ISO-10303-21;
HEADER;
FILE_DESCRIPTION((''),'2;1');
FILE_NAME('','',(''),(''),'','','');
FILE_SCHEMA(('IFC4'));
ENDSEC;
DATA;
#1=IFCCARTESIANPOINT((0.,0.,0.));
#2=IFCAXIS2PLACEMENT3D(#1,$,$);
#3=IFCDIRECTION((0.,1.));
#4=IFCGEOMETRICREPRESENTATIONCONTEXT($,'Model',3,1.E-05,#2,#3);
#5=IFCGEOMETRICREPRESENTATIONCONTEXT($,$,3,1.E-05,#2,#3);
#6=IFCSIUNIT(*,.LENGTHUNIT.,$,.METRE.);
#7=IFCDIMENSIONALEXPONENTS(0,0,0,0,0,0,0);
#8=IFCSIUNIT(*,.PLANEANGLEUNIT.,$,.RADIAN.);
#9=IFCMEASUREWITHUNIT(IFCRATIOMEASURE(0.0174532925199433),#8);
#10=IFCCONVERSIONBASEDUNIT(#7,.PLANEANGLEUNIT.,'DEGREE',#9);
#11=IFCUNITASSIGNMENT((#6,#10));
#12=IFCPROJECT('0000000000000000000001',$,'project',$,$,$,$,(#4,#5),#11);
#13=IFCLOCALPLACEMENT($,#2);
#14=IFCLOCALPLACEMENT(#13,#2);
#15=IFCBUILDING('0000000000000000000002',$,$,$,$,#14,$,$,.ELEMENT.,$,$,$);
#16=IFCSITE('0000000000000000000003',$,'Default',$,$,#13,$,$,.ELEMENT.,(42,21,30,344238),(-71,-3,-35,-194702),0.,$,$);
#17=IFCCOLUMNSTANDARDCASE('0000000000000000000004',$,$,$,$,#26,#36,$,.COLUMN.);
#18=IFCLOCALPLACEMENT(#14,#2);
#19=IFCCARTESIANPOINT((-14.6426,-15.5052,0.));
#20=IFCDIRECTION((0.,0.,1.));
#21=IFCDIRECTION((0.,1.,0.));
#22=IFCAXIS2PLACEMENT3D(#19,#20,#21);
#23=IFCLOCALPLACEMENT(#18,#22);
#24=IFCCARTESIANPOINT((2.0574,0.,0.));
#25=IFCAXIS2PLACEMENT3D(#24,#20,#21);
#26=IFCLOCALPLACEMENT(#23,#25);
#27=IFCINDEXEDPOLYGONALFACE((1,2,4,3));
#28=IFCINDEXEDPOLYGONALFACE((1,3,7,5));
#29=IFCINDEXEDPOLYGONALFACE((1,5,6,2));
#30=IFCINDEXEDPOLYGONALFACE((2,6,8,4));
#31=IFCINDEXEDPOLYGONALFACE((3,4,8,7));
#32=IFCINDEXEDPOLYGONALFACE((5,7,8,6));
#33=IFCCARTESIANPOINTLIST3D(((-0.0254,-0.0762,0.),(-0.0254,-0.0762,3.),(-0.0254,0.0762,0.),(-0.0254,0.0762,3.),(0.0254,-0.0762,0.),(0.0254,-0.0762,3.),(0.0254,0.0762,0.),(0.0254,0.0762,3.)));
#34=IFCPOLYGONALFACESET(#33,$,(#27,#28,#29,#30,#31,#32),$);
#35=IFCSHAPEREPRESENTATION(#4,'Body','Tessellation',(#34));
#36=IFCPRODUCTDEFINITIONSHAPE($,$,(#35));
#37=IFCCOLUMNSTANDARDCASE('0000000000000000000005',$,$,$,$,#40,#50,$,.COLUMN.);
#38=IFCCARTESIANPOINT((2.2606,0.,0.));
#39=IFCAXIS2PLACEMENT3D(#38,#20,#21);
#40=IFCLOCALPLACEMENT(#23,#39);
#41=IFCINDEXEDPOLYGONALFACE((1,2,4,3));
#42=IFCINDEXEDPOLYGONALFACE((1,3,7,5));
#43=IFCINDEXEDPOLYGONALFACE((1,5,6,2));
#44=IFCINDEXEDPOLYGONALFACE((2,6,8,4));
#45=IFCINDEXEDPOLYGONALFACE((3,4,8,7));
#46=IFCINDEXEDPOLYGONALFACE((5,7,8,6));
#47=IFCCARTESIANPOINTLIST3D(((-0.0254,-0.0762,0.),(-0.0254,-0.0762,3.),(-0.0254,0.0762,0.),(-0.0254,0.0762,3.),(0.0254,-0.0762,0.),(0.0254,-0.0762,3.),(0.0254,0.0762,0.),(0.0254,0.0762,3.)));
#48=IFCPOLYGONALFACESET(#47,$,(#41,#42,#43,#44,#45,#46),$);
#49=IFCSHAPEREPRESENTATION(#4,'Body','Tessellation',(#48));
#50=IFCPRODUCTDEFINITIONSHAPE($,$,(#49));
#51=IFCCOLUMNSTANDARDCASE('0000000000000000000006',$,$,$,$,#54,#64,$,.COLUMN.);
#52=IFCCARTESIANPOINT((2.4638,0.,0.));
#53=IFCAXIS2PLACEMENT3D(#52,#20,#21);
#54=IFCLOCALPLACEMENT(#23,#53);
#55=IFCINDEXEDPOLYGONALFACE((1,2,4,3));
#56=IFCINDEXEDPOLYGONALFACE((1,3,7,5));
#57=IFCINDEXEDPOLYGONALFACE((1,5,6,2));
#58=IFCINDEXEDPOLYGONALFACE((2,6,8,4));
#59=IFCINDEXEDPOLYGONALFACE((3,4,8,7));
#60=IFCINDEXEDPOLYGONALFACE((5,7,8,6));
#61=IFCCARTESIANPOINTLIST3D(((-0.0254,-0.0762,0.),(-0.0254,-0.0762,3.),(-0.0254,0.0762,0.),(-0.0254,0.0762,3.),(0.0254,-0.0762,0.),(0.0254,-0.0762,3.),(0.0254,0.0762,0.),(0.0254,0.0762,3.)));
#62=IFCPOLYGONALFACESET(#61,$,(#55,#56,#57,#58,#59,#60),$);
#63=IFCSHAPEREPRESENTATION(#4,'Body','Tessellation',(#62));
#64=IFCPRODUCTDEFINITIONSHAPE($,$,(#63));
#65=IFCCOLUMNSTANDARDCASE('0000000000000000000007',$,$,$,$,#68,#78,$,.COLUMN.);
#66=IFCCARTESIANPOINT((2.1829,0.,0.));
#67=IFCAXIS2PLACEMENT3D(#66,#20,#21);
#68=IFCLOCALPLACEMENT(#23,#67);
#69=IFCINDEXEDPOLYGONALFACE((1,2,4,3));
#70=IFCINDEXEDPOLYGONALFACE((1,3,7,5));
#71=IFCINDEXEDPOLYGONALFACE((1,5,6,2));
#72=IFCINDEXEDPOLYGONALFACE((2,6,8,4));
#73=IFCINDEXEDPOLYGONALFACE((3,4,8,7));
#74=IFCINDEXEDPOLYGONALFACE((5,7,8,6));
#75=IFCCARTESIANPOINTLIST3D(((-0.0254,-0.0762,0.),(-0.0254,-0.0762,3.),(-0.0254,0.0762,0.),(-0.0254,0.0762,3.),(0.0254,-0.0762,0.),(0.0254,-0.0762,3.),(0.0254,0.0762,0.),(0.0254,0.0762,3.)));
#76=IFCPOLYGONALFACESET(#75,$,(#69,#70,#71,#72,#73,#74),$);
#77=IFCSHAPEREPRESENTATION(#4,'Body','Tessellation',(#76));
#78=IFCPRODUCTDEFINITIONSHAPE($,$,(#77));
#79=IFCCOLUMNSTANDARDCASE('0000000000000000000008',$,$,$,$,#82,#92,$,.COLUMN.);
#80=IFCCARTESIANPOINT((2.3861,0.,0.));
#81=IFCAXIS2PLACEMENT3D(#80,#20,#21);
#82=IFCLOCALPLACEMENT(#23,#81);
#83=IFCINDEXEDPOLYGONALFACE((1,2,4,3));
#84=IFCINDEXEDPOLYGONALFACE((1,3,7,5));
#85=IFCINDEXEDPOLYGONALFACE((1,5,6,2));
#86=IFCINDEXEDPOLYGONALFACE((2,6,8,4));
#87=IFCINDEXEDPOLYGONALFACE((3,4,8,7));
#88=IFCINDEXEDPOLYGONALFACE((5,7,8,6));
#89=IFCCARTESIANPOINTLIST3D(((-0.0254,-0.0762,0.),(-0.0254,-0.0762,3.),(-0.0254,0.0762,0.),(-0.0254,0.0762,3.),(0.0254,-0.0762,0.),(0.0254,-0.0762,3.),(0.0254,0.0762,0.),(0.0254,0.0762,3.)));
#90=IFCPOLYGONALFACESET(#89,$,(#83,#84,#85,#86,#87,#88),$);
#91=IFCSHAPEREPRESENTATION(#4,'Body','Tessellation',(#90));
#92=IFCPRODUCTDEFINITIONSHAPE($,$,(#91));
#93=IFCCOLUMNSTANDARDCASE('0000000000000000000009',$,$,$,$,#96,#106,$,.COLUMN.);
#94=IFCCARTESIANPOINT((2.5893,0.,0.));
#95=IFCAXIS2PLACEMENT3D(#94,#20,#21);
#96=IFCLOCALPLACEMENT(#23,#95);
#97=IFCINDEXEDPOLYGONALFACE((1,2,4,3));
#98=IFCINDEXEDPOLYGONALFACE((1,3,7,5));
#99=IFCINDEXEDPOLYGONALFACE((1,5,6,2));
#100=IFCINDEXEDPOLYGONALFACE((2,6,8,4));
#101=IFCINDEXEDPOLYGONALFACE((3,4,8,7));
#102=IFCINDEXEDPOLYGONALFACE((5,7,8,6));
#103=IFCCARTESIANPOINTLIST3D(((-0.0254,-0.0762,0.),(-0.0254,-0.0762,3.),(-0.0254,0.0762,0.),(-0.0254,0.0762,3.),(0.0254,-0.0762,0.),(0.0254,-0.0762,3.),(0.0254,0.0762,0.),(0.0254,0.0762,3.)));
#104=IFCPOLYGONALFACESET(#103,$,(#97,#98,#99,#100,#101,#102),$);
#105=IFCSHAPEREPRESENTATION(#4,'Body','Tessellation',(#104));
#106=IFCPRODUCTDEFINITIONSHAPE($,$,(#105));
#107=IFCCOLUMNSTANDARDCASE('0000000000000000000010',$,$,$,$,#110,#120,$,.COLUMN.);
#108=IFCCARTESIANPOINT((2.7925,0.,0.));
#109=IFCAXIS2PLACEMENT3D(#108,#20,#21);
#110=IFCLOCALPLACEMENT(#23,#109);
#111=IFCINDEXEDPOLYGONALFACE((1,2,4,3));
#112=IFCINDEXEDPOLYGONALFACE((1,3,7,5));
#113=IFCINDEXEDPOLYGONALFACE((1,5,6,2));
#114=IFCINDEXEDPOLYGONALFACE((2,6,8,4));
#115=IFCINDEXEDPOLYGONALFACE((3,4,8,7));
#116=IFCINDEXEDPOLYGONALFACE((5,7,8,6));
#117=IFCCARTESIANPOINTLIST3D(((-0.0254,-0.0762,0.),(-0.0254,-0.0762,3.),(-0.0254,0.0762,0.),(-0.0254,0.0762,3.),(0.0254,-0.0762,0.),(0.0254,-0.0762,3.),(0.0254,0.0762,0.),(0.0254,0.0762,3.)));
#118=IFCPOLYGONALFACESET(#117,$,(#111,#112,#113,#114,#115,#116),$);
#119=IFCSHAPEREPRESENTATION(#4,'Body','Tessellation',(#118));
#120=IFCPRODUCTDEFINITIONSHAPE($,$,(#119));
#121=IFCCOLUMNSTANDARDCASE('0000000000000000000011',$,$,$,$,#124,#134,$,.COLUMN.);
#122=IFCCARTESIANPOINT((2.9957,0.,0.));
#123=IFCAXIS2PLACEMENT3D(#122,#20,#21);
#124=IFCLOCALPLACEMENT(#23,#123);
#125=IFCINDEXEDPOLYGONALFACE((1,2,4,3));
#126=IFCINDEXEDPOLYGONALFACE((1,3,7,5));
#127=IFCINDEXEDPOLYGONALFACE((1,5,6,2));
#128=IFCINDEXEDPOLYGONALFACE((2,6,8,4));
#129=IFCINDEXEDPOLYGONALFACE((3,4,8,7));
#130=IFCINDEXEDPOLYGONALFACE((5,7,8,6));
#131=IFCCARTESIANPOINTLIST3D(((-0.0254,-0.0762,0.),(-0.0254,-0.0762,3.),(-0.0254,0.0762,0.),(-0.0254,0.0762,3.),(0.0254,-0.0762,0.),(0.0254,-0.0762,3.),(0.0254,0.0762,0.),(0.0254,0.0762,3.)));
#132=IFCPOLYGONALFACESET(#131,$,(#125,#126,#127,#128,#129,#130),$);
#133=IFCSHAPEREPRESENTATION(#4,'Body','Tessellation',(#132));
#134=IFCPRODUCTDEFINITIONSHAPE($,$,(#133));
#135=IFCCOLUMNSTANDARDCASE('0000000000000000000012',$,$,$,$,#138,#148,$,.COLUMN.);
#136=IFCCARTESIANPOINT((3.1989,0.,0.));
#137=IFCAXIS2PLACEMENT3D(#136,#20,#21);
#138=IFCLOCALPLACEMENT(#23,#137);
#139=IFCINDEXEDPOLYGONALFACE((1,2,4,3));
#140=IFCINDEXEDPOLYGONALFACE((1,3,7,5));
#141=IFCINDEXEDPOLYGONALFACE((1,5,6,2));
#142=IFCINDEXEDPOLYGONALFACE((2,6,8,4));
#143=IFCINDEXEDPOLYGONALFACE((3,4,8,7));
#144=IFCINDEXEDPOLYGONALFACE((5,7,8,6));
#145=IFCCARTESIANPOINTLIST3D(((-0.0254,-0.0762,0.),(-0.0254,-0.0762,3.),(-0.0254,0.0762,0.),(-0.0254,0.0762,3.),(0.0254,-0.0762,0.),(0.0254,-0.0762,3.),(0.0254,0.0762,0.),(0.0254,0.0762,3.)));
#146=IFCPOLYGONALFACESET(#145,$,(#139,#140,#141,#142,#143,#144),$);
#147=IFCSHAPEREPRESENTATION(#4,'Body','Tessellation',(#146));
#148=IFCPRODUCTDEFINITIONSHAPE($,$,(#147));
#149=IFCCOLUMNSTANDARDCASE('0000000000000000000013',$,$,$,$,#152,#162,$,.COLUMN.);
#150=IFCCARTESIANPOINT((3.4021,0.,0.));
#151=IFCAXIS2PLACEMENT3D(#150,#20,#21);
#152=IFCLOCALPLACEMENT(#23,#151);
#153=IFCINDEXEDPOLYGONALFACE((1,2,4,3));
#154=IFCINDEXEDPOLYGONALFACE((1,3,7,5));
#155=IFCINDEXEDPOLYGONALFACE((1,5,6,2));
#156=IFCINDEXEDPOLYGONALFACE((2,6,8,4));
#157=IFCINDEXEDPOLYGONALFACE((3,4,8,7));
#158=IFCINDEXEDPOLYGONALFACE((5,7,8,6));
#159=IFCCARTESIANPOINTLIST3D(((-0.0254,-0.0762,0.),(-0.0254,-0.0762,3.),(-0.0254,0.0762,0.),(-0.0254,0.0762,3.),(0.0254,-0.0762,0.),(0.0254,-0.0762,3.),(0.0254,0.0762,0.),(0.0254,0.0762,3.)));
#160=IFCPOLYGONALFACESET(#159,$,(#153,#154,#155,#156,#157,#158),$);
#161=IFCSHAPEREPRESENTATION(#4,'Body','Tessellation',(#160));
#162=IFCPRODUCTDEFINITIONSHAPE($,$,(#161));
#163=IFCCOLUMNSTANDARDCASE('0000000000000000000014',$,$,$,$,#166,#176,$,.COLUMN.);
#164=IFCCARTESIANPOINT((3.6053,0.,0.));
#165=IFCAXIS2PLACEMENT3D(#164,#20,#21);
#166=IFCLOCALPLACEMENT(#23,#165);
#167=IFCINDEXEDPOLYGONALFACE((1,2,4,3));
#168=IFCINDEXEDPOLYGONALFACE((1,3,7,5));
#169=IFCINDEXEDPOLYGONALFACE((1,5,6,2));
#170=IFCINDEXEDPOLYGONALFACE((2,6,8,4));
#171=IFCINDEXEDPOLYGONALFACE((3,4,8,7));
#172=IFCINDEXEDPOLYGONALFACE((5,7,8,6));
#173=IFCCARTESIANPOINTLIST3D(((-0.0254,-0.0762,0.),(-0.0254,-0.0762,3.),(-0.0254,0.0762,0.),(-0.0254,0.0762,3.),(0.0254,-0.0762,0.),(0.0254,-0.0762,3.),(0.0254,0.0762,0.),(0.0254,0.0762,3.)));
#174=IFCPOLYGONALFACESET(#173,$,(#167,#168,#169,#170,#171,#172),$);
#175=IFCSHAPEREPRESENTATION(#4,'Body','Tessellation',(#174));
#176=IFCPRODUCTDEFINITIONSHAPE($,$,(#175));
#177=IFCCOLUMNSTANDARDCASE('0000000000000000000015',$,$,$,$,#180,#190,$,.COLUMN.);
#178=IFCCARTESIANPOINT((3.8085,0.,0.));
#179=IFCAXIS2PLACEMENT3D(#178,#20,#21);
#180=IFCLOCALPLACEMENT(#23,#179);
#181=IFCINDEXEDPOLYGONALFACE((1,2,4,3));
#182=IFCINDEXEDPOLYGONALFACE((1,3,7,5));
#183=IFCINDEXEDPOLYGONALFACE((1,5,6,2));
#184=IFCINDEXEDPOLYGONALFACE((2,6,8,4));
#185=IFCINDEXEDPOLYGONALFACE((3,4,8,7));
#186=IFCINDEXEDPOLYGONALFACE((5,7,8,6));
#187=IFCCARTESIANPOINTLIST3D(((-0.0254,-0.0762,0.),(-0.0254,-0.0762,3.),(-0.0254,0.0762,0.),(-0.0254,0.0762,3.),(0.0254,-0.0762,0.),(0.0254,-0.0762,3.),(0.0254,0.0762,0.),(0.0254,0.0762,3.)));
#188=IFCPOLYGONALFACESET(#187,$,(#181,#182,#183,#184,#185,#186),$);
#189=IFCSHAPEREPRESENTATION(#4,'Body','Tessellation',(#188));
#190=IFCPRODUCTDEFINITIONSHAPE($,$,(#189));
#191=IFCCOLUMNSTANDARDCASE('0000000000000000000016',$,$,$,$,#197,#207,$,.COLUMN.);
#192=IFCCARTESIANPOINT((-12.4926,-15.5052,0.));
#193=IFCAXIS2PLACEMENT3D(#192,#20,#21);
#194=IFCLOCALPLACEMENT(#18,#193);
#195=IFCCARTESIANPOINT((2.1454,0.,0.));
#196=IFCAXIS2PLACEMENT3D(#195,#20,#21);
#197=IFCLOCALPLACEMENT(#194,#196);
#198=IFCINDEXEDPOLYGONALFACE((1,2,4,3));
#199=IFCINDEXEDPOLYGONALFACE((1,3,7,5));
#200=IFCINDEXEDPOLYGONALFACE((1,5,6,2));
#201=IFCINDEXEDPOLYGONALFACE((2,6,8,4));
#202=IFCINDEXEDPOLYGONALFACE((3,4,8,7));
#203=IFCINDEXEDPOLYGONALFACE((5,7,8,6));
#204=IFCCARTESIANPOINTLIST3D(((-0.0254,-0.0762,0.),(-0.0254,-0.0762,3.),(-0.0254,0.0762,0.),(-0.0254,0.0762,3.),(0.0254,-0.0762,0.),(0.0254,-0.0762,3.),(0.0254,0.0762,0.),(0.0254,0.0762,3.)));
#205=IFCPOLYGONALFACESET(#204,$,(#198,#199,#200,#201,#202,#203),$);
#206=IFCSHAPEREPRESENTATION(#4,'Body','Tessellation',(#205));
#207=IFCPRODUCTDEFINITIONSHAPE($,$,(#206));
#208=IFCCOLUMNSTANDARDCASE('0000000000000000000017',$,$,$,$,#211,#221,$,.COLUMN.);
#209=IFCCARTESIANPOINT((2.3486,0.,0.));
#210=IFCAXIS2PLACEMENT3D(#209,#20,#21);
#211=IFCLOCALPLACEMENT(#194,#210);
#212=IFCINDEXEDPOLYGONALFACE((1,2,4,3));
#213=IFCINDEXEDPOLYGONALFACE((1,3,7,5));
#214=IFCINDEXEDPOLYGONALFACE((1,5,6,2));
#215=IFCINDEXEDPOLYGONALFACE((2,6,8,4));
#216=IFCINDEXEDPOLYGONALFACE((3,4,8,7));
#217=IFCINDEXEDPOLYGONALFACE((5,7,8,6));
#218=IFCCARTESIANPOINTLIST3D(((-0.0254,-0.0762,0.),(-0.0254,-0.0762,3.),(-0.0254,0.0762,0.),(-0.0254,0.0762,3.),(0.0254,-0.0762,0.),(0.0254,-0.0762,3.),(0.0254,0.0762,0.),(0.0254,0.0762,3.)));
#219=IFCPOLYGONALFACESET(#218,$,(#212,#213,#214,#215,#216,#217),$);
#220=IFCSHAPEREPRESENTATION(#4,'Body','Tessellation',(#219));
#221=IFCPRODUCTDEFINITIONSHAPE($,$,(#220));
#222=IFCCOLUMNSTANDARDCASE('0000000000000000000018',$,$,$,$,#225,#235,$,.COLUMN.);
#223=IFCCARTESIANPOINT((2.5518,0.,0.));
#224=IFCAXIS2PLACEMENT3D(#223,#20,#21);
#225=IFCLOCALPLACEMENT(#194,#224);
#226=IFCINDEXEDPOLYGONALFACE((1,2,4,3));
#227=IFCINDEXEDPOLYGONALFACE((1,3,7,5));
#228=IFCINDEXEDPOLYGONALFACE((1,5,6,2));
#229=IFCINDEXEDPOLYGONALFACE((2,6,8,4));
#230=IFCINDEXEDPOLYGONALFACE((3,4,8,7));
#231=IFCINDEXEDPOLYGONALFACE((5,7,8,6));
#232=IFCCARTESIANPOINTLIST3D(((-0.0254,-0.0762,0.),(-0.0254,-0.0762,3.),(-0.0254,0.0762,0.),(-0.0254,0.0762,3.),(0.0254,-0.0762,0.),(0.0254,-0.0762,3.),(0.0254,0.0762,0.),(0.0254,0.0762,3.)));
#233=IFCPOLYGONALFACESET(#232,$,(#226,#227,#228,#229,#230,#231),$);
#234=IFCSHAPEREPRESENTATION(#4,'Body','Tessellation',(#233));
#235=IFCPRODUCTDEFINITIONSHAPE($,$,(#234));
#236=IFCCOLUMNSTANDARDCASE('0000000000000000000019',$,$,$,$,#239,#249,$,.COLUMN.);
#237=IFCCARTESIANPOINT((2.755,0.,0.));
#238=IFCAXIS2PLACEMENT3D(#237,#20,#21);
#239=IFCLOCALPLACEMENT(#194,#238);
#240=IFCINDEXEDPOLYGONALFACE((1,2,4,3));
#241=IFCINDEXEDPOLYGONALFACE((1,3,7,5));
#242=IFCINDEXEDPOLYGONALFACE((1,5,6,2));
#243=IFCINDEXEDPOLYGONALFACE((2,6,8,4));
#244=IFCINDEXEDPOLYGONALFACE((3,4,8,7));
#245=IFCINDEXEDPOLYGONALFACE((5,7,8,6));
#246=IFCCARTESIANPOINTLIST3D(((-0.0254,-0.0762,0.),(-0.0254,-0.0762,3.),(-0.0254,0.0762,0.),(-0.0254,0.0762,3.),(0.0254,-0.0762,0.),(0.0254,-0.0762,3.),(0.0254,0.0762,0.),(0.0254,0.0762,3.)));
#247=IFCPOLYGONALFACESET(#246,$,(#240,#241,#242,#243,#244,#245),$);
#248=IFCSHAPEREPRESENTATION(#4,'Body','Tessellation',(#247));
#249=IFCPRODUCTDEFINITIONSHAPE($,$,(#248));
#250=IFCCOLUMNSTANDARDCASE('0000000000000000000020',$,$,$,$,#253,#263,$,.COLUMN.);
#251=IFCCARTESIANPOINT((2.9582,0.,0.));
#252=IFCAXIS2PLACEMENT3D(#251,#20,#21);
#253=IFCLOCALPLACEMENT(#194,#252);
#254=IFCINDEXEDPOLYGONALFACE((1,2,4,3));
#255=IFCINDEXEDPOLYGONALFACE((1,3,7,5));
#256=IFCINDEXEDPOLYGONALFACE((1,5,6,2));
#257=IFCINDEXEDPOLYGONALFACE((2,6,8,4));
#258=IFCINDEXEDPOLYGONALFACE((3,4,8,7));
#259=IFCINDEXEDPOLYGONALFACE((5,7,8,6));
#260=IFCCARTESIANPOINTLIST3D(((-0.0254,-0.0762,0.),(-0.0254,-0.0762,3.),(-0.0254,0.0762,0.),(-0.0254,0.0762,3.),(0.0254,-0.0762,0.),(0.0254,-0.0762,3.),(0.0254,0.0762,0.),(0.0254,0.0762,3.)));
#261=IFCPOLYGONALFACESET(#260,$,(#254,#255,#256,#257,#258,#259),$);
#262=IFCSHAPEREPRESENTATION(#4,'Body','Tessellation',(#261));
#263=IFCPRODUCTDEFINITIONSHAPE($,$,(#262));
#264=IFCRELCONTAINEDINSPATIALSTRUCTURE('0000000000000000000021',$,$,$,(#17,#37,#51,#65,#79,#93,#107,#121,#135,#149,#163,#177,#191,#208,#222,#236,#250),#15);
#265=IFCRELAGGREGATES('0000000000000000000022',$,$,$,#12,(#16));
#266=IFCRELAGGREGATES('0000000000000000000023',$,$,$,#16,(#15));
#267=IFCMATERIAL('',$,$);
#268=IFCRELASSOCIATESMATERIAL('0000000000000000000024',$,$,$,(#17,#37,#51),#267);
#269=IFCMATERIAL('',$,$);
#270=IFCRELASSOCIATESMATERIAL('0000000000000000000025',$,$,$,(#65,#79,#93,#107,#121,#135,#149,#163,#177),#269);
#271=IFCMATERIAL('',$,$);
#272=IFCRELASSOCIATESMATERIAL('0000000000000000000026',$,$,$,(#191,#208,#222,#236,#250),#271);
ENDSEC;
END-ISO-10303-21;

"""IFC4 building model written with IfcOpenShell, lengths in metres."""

from ifc_helpers import new_model, entity, si_unit, converted_unit, direction, frame, origin, place, context, project, spatial, rectangle, extrude, material, element, save


model = new_model("IFC4")

# Units and contexts
model_context = context("Model", 3, precision=1e-05, world=origin(), true_north=direction((0.0, 1.0)))
context_of_model = context(None, 3, precision=1e-05, world=origin(), true_north=direction((0.0, 1.0)))
ifc_project = project(units=[si_unit("LENGTHUNIT", "METRE"), converted_unit("PLANEANGLEUNIT", "DEGREE", entity("IfcRatioMeasure", 0.0174532925199433), si_unit("PLANEANGLEUNIT", "RADIAN"), dimensions=[0, 0, 0, 0, 0, 0, 0])], contexts=[model_context, context_of_model])

# Site, building
site_placement = place(None, origin())
site = spatial("IfcSite", under=ifc_project, at=site_placement, Name="Default", CompositionType="ELEMENT", RefLatitude=(42, 21, 30, 344238), RefLongitude=(-71, -3, -35, -194702), RefElevation=0.0)
building_placement = place(site_placement, origin())
building = spatial("IfcBuilding", under=site, at=building_placement, CompositionType="ELEMENT")

# Columns
ifc_material_1 = material(Name="")
placement_1 = place(building_placement, origin())
placement_2 = place(placement_1, frame((-14.6426, -15.5052, 0.0), z_axis=(0.0, 0.0, 1.0), x_axis=(0.0, 1.0, 0.0)))
for number, where, z_axis, x_axis in (
    (1, (2.0574, 0.0, 0.0), (0.0, 0.0, 1.0), (0.0, 1.0, 0.0)),
    (2, (2.2606, 0.0, 0.0), (0.0, 0.0, 1.0), (0.0, 1.0, 0.0)),
    (3, (2.4638, 0.0, 0.0), (0.0, 0.0, 1.0), (0.0, 1.0, 0.0)),
):
    element("IfcColumnStandardCase", number, at=place(placement_2, frame(where, z_axis=z_axis, x_axis=x_axis)), inside=building, material=ifc_material_1, PredefinedType="COLUMN", context=model_context, shape_type="SweptSolid", body=[
        extrude(rectangle(XDim=0.0508, YDim=0.1524), origin(), (0.0, 0.0, 1.0), 3.0),
    ])
ifc_material_2 = material(Name="")
for number, where, z_axis, x_axis in (
    (4, (2.1829, 0.0, 0.0), (0.0, 0.0, 1.0), (0.0, 1.0, 0.0)),
    (5, (2.3861, 0.0, 0.0), (0.0, 0.0, 1.0), (0.0, 1.0, 0.0)),
    (6, (2.5893, 0.0, 0.0), (0.0, 0.0, 1.0), (0.0, 1.0, 0.0)),
    (7, (2.7925, 0.0, 0.0), (0.0, 0.0, 1.0), (0.0, 1.0, 0.0)),
    (8, (2.9957, 0.0, 0.0), (0.0, 0.0, 1.0), (0.0, 1.0, 0.0)),
    (9, (3.1989, 0.0, 0.0), (0.0, 0.0, 1.0), (0.0, 1.0, 0.0)),
    (10, (3.4021, 0.0, 0.0), (0.0, 0.0, 1.0), (0.0, 1.0, 0.0)),
    (11, (3.6053, 0.0, 0.0), (0.0, 0.0, 1.0), (0.0, 1.0, 0.0)),
    (12, (3.8085, 0.0, 0.0), (0.0, 0.0, 1.0), (0.0, 1.0, 0.0)),
):
    element("IfcColumnStandardCase", number, at=place(placement_2, frame(where, z_axis=z_axis, x_axis=x_axis)), inside=building, material=ifc_material_2, PredefinedType="COLUMN", context=model_context, shape_type="SweptSolid", body=[
        extrude(rectangle(XDim=0.0508, YDim=0.1524), origin(), (0.0, 0.0, 1.0), 3.0),
    ])
ifc_material_3 = material(Name="")
placement_3 = place(placement_1, frame((-12.4926, -15.5052, 0.0), z_axis=(0.0, 0.0, 1.0), x_axis=(0.0, 1.0, 0.0)))
for number, where, z_axis, x_axis in (
    (13, (2.1454, 0.0, 0.0), (0.0, 0.0, 1.0), (0.0, 1.0, 0.0)),
    (14, (2.3486, 0.0, 0.0), (0.0, 0.0, 1.0), (0.0, 1.0, 0.0)),
    (15, (2.5518, 0.0, 0.0), (0.0, 0.0, 1.0), (0.0, 1.0, 0.0)),
    (16, (2.755, 0.0, 0.0), (0.0, 0.0, 1.0), (0.0, 1.0, 0.0)),
    (17, (2.9582, 0.0, 0.0), (0.0, 0.0, 1.0), (0.0, 1.0, 0.0)),
):
    element("IfcColumnStandardCase", number, at=place(placement_3, frame(where, z_axis=z_axis, x_axis=x_axis)), inside=building, material=ifc_material_3, PredefinedType="COLUMN", context=model_context, shape_type="SweptSolid", body=[
        extrude(rectangle(XDim=0.0508, YDim=0.1524), origin(), (0.0, 0.0, 1.0), 3.0),
    ])

save(model, "model.ifc")
